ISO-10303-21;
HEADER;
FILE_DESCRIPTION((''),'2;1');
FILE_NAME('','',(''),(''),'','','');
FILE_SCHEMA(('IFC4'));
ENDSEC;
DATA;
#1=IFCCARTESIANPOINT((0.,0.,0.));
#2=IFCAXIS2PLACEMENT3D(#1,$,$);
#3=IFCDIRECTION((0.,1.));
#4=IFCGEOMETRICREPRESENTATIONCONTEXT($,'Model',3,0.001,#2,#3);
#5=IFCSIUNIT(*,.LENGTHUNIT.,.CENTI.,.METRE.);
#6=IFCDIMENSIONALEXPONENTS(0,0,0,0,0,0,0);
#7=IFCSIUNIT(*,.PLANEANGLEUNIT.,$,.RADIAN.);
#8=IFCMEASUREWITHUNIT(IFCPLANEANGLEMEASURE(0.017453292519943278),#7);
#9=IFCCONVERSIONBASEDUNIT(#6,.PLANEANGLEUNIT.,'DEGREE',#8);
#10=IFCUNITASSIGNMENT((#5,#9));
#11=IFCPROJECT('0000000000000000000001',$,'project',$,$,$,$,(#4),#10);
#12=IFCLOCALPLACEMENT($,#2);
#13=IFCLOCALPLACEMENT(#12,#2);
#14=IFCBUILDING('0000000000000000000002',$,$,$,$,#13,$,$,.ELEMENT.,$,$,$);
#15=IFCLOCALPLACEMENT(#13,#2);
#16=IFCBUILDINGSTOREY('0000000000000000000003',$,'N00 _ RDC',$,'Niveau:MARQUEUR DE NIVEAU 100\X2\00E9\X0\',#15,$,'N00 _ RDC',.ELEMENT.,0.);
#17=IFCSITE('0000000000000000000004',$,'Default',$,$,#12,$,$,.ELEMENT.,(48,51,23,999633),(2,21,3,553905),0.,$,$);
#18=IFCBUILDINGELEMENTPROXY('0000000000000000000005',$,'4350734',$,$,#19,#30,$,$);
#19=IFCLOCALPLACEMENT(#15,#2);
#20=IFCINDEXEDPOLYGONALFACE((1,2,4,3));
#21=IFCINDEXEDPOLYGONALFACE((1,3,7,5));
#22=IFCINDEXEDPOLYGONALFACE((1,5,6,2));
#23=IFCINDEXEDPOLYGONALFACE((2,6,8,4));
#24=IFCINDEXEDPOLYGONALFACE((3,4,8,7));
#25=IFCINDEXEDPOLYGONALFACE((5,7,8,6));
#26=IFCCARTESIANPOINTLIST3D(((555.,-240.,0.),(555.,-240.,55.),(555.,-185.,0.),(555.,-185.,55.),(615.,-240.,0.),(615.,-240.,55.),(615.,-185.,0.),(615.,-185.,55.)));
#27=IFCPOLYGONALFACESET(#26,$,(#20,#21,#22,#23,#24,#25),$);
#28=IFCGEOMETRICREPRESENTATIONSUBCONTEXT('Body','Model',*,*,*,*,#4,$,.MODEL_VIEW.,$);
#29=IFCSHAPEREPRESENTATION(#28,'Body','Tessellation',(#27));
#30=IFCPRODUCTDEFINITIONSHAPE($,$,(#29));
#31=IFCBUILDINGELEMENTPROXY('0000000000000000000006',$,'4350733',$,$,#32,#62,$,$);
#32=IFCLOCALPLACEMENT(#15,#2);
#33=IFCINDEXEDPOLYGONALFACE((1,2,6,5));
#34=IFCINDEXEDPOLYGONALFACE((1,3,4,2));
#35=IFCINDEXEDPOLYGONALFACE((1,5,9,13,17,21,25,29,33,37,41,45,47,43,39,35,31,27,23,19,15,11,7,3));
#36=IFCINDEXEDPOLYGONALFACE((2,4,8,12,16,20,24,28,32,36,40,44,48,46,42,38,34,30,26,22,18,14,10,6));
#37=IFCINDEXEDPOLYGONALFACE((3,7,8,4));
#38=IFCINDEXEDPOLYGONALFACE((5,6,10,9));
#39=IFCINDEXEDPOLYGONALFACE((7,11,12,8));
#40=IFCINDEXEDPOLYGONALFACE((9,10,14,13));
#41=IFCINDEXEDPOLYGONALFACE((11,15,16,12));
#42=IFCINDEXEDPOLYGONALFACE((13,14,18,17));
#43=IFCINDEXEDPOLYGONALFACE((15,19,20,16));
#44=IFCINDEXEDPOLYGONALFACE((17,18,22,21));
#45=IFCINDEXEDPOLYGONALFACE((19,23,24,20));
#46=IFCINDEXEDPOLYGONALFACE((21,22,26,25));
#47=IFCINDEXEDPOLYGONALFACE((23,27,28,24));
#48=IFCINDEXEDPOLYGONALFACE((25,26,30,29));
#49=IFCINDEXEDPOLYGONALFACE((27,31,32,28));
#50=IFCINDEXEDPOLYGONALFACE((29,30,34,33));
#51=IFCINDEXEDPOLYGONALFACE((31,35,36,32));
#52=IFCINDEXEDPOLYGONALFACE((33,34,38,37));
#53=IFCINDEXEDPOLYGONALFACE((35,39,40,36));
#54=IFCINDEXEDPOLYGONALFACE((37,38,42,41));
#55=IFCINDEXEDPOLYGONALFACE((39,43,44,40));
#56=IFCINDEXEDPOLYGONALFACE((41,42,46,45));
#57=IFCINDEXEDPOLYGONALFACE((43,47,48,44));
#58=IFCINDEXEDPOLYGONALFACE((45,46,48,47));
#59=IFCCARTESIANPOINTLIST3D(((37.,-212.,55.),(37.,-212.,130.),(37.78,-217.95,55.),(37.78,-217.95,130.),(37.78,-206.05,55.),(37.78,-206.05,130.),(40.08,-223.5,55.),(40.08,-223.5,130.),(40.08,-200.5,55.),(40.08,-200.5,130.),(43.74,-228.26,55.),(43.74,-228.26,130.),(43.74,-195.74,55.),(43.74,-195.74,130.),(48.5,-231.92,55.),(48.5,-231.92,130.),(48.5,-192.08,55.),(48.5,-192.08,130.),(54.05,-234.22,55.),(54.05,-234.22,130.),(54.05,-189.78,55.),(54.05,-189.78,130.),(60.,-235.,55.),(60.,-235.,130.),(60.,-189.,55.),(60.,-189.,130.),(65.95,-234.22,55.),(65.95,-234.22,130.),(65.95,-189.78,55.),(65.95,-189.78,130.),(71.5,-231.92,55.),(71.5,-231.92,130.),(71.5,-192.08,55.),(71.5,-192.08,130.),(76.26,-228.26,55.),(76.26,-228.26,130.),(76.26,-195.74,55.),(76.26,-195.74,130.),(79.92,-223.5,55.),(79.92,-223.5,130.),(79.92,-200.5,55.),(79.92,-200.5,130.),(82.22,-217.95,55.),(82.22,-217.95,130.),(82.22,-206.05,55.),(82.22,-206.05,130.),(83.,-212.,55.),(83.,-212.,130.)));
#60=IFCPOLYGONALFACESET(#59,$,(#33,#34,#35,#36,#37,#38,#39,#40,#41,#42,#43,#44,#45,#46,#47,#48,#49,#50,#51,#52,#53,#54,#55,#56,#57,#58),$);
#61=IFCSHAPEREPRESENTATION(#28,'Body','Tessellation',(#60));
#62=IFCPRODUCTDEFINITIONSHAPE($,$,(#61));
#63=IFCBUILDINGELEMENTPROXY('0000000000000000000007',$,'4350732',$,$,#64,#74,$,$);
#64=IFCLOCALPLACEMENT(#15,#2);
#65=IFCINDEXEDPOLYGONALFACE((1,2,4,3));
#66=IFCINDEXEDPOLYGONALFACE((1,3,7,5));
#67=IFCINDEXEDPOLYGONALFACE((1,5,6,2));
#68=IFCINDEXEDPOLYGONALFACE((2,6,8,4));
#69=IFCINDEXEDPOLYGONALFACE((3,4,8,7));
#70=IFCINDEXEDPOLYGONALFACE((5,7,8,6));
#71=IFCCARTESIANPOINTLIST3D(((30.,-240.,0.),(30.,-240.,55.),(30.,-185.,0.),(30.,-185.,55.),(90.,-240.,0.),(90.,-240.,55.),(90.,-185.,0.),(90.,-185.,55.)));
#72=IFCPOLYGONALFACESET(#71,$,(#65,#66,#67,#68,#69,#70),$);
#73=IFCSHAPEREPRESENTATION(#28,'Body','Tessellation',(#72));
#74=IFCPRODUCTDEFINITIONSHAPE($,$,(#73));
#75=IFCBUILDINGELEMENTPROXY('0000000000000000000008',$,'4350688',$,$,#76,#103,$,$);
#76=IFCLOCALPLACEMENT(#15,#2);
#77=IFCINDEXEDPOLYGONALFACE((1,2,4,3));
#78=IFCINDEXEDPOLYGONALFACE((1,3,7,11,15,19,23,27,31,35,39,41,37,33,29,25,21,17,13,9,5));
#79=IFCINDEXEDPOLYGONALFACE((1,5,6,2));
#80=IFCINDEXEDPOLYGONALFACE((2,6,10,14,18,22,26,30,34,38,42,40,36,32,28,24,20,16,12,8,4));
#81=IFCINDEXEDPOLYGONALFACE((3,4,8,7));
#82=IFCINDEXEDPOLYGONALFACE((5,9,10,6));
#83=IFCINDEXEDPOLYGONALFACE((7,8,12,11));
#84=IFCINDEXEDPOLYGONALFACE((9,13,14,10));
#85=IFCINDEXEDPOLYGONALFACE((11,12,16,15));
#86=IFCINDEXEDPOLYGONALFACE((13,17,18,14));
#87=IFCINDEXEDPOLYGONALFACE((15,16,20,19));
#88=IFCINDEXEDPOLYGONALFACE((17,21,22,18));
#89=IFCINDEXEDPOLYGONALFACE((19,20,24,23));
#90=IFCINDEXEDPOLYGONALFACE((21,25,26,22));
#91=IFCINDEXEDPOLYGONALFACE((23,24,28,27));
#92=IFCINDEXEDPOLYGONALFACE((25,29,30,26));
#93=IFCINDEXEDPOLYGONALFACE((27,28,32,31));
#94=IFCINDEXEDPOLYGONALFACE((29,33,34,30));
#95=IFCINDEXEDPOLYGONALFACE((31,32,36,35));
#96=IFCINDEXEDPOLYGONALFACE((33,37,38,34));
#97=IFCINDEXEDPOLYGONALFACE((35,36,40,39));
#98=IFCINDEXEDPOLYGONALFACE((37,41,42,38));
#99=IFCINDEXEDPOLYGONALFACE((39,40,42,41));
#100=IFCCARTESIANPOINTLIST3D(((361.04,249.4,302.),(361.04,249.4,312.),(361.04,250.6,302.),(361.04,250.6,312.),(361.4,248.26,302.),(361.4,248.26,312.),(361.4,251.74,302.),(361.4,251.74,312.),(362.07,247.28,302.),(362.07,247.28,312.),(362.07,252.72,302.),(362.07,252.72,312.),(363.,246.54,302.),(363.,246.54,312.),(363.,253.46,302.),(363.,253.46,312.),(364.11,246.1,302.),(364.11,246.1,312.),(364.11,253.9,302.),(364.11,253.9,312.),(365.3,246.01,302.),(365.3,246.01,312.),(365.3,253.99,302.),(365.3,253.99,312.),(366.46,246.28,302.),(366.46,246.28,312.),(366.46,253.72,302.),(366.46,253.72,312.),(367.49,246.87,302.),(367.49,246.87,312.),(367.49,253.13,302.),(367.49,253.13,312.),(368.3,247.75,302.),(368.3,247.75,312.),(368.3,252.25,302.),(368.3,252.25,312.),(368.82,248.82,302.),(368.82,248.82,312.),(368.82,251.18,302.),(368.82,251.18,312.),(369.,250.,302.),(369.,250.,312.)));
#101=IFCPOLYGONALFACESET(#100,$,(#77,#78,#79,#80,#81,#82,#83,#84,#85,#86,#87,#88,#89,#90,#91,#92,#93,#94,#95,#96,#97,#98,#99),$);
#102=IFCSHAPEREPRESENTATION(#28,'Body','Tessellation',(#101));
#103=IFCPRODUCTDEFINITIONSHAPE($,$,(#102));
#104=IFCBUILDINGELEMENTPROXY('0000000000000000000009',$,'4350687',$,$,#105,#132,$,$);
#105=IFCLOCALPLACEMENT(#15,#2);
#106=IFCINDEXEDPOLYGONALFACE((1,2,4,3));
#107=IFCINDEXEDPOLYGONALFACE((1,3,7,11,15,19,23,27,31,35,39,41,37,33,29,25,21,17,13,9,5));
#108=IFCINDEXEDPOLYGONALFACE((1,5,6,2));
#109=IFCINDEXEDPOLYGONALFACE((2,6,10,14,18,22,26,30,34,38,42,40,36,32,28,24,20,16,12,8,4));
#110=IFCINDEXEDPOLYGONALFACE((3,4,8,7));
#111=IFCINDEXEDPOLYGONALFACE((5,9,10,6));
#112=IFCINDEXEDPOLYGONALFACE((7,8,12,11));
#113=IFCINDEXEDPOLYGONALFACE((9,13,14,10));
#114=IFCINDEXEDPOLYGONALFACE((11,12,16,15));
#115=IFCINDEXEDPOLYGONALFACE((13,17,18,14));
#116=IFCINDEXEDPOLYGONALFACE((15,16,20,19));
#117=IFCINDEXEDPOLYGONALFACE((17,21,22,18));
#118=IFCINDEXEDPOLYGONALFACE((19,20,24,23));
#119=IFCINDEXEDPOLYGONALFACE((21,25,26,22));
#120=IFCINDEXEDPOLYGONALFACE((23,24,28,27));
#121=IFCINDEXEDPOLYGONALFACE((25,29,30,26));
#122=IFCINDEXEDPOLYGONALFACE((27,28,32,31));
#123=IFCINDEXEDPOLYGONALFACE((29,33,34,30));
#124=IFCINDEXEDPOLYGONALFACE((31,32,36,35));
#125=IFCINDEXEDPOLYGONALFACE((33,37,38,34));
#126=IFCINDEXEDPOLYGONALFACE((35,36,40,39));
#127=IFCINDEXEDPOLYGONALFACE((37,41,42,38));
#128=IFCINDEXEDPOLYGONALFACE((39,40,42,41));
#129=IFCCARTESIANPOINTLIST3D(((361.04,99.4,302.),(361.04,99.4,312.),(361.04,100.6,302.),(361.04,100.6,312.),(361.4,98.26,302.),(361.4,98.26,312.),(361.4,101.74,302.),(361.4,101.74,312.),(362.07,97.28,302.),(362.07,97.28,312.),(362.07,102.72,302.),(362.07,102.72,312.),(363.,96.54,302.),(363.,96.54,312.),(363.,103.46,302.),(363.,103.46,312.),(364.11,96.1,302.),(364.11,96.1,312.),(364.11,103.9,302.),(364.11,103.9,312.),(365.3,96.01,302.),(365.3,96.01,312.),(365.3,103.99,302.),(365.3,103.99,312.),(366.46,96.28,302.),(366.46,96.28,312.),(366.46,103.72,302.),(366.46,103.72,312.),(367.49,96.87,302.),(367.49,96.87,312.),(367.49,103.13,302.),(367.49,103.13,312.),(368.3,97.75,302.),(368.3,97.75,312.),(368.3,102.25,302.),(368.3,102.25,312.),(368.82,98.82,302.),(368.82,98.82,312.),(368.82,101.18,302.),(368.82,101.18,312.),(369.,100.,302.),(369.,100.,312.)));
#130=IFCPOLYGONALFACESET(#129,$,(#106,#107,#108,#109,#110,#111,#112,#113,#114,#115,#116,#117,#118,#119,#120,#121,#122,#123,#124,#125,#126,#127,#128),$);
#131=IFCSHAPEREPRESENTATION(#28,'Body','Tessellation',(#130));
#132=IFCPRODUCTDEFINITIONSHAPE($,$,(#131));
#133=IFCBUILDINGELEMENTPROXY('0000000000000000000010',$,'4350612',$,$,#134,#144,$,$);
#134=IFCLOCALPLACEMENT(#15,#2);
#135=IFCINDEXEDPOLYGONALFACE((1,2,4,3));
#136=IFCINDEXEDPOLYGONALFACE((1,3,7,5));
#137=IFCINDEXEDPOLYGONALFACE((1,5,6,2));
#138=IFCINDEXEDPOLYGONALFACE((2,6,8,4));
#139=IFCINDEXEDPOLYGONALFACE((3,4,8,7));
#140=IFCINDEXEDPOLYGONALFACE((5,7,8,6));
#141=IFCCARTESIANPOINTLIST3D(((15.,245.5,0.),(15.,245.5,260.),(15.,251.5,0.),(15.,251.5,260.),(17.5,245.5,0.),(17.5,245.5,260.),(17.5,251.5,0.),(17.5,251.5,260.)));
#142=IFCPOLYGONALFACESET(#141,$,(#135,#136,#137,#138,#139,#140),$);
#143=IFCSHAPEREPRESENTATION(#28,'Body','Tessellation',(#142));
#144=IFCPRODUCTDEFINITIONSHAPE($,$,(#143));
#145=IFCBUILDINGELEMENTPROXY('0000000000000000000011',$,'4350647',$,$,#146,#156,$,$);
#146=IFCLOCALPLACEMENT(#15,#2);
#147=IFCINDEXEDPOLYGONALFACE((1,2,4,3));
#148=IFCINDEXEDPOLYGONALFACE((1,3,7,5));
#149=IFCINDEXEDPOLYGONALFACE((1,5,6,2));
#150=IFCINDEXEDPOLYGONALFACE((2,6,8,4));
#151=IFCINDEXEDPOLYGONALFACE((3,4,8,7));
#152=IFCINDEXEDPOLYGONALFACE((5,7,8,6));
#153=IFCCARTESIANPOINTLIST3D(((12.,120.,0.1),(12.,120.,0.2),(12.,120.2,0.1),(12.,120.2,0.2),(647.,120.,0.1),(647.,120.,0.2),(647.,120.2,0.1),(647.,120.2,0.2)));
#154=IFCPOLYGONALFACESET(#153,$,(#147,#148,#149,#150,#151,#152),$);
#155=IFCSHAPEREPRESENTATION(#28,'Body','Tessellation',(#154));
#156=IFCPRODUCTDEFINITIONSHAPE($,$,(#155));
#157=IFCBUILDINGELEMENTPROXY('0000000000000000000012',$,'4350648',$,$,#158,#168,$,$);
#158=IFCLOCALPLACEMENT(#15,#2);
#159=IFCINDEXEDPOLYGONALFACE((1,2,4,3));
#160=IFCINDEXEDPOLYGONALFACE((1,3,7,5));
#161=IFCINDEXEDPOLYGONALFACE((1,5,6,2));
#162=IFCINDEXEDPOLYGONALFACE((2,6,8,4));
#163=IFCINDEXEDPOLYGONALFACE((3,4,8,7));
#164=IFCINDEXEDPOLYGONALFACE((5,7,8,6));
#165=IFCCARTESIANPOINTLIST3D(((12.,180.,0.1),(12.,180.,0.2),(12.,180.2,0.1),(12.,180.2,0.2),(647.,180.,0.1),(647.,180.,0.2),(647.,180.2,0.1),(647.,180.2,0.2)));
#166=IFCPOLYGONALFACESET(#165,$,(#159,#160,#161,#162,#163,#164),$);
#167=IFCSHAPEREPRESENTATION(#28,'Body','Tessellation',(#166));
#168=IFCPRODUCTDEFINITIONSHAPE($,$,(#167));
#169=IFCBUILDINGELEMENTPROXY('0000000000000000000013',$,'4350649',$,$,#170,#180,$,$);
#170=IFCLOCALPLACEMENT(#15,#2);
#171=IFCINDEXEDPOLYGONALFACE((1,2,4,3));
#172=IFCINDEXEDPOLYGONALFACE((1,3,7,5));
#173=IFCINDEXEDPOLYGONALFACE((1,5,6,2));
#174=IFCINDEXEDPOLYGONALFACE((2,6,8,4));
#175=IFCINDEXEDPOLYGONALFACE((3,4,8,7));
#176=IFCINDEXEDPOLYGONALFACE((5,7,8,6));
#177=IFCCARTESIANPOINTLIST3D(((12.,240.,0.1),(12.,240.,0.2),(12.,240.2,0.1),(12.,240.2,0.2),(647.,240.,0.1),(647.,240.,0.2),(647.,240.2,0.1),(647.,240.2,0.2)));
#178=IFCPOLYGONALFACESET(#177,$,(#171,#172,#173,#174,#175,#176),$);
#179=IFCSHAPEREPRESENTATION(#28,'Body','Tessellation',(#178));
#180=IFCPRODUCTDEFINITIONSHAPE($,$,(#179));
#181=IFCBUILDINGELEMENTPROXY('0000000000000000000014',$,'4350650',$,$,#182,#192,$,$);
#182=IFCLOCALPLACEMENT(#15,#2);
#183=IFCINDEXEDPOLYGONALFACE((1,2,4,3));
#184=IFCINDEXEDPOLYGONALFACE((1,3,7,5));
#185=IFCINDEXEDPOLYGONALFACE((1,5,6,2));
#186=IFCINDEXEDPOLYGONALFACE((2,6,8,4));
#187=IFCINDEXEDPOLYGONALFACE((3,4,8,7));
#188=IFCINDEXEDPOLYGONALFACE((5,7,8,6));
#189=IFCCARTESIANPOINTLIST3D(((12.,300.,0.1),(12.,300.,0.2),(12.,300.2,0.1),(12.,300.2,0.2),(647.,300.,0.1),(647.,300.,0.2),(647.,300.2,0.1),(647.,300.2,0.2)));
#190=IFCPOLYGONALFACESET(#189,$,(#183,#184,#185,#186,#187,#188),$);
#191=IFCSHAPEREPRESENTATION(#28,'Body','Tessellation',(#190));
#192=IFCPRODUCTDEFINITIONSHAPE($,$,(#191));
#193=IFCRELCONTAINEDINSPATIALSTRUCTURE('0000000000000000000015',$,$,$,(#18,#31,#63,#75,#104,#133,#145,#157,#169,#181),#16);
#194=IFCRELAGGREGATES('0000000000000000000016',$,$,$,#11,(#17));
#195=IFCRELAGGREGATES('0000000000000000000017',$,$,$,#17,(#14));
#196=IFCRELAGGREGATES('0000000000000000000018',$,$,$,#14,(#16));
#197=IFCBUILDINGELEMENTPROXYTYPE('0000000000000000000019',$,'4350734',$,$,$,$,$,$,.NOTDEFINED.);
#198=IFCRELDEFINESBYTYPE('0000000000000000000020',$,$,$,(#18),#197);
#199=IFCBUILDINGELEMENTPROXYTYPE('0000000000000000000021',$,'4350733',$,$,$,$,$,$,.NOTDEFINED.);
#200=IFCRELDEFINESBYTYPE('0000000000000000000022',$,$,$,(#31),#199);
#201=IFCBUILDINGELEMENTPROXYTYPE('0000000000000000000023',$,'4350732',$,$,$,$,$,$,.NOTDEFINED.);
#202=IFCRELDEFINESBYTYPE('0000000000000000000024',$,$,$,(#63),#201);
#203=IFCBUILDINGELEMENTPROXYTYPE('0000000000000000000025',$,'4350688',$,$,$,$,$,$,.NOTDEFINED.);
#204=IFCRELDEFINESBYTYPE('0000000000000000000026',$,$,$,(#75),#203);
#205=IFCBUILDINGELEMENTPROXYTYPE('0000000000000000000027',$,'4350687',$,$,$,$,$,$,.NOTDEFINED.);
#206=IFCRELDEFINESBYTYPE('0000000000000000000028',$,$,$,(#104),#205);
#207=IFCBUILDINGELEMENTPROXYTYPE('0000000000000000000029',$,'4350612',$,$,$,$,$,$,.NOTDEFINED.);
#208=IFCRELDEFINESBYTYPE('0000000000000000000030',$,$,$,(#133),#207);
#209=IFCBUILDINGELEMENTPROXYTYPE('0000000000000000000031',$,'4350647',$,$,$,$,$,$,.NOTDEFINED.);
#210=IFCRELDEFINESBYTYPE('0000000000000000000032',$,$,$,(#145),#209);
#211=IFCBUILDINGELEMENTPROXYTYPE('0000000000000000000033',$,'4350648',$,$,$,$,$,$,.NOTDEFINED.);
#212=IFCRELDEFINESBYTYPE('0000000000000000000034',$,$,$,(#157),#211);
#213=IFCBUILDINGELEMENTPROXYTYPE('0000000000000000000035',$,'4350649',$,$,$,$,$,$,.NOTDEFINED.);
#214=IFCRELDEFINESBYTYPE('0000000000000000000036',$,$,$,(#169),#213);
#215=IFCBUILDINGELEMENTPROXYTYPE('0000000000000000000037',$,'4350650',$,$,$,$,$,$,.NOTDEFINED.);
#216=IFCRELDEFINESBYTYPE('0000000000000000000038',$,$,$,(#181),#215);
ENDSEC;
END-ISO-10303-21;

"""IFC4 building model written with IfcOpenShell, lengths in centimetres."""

from ifc_helpers import new_model, entity, si_unit, converted_unit, direction, frame, frame_2d, origin, origin_2d_with_axis, place, context, subcontext, project, spatial, rectangle, circle, extrude, type_object, element, save


model = new_model("IFC4")

# Units and contexts
model_context = context("Model", 3, precision=0.001, world=origin(), true_north=direction((0.0, 1.0)))
body_context = subcontext(model_context, "Body", "Model", "MODEL_VIEW")
ifc_project = project(units=[si_unit("LENGTHUNIT", "METRE", prefix="CENTI"), converted_unit("PLANEANGLEUNIT", "DEGREE", entity("IfcPlaneAngleMeasure", 0.017453292519943278), si_unit("PLANEANGLEUNIT", "RADIAN"), dimensions=[0, 0, 0, 0, 0, 0, 0])], contexts=[model_context])

# Site, building, storey
site_placement = place(None, origin())
site = spatial("IfcSite", under=ifc_project, at=site_placement, Name="Default", CompositionType="ELEMENT", RefLatitude=(48, 51, 23, 999633), RefLongitude=(2, 21, 3, 553905), RefElevation=0.0)
building_placement = place(site_placement, origin())
building = spatial("IfcBuilding", under=site, at=building_placement, CompositionType="ELEMENT")
storey_placement = place(building_placement, origin())
storey = spatial("IfcBuildingStorey", under=building, at=storey_placement, Name="N00 _ RDC", ObjectType="Niveau:MARQUEUR DE NIVEAU 100é", LongName="N00 _ RDC", CompositionType="ELEMENT", Elevation=0.0)

# Building element proxies
building_element_proxy_type_1 = type_object("IfcBuildingElementProxyType", Name="4350734", PredefinedType="NOTDEFINED")
proxy_1_placement = place(storey_placement, origin())
element("IfcBuildingElementProxy", 1, at=proxy_1_placement, inside=storey, type_object=building_element_proxy_type_1, Name="4350734", context=body_context, shape_type="SweptSolid", body=[
    extrude(rectangle(XDim=60.0, YDim=55.0, at=origin_2d_with_axis()), frame((585.0, -212.5, 0.0)), (0.0, 0.0, 1.0), 55.0),
])
building_element_proxy_type_2 = type_object("IfcBuildingElementProxyType", Name="4350733", PredefinedType="NOTDEFINED")
proxy_2_placement = place(storey_placement, origin())
element("IfcBuildingElementProxy", 2, at=proxy_2_placement, inside=storey, type_object=building_element_proxy_type_2, Name="4350733", context=body_context, shape_type="SweptSolid", body=[
    extrude(circle(Radius=23.0, at=origin_2d_with_axis()), frame((60.0, -212.0, 55.0)), (0.0, 0.0, 1.0), 75.0),
])
building_element_proxy_type_3 = type_object("IfcBuildingElementProxyType", Name="4350732", PredefinedType="NOTDEFINED")
proxy_3_placement = place(storey_placement, origin())
element("IfcBuildingElementProxy", 3, at=proxy_3_placement, inside=storey, type_object=building_element_proxy_type_3, Name="4350732", context=body_context, shape_type="SweptSolid", body=[
    extrude(rectangle(XDim=60.0, YDim=55.0, at=frame_2d((0.0, 0.0), x_axis=(1.0, 0.0))), frame((60.0, -212.5, 0.0)), (0.0, 0.0, 1.0), 55.0),
])
building_element_proxy_type_4 = type_object("IfcBuildingElementProxyType", Name="4350688", PredefinedType="NOTDEFINED")
proxy_4_placement = place(storey_placement, origin())
element("IfcBuildingElementProxy", 4, at=proxy_4_placement, inside=storey, type_object=building_element_proxy_type_4, Name="4350688", context=body_context, shape_type="SweptSolid", body=[
    extrude(circle(Radius=4.0, at=origin_2d_with_axis()), frame((365.0, 250.0, 302.0)), (0.0, 0.0, 1.0), 10.0),
])
building_element_proxy_type_5 = type_object("IfcBuildingElementProxyType", Name="4350687", PredefinedType="NOTDEFINED")
proxy_5_placement = place(storey_placement, origin())
element("IfcBuildingElementProxy", 5, at=proxy_5_placement, inside=storey, type_object=building_element_proxy_type_5, Name="4350687", context=body_context, shape_type="SweptSolid", body=[
    extrude(circle(Radius=4.0, at=origin_2d_with_axis()), frame((365.0, 100.0, 302.0)), (0.0, 0.0, 1.0), 10.0),
])
building_element_proxy_type_6 = type_object("IfcBuildingElementProxyType", Name="4350612", PredefinedType="NOTDEFINED")
proxy_6_placement = place(storey_placement, origin())
element("IfcBuildingElementProxy", 6, at=proxy_6_placement, inside=storey, type_object=building_element_proxy_type_6, Name="4350612", context=body_context, shape_type="SweptSolid", body=[
    extrude(rectangle(XDim=2.5, YDim=6.0, at=frame_2d((0.0, 0.0), x_axis=(1.0, 0.0))), frame((16.25, 248.5, 0.0)), (0.0, 0.0, 1.0), 260.0),
])
building_element_proxy_type_7 = type_object("IfcBuildingElementProxyType", Name="4350647", PredefinedType="NOTDEFINED")
proxy_7_placement = place(storey_placement, origin())
element("IfcBuildingElementProxy", 7, at=proxy_7_placement, inside=storey, type_object=building_element_proxy_type_7, Name="4350647", context=body_context, shape_type="SweptSolid", body=[
    extrude(rectangle(XDim=635.0, YDim=0.2, at=frame_2d((0.0, 0.0), x_axis=(1.0, 0.0))), frame((329.5, 120.1, 0.1)), (0.0, 0.0, 1.0), 0.1),
])
building_element_proxy_type_8 = type_object("IfcBuildingElementProxyType", Name="4350648", PredefinedType="NOTDEFINED")
proxy_8_placement = place(storey_placement, origin())
element("IfcBuildingElementProxy", 8, at=proxy_8_placement, inside=storey, type_object=building_element_proxy_type_8, Name="4350648", context=body_context, shape_type="SweptSolid", body=[
    extrude(rectangle(XDim=635.0, YDim=0.2, at=frame_2d((0.0, 0.0), x_axis=(1.0, 0.0))), frame((329.5, 180.1, 0.1)), (0.0, 0.0, 1.0), 0.1),
])
building_element_proxy_type_9 = type_object("IfcBuildingElementProxyType", Name="4350649", PredefinedType="NOTDEFINED")
proxy_9_placement = place(storey_placement, origin())
element("IfcBuildingElementProxy", 9, at=proxy_9_placement, inside=storey, type_object=building_element_proxy_type_9, Name="4350649", context=body_context, shape_type="SweptSolid", body=[
    extrude(rectangle(XDim=635.0, YDim=0.2, at=frame_2d((0.0, 0.0), x_axis=(1.0, 0.0))), frame((329.5, 240.1, 0.1)), (0.0, 0.0, 1.0), 0.1),
])
building_element_proxy_type_10 = type_object("IfcBuildingElementProxyType", Name="4350650", PredefinedType="NOTDEFINED")
proxy_10_placement = place(storey_placement, origin())
element("IfcBuildingElementProxy", 10, at=proxy_10_placement, inside=storey, type_object=building_element_proxy_type_10, Name="4350650", context=body_context, shape_type="SweptSolid", body=[
    extrude(rectangle(XDim=635.0, YDim=0.2, at=frame_2d((0.0, 0.0), x_axis=(1.0, 0.0))), frame((329.5, 300.1, 0.1)), (0.0, 0.0, 1.0), 0.1),
])

save(model, "model.ifc")
